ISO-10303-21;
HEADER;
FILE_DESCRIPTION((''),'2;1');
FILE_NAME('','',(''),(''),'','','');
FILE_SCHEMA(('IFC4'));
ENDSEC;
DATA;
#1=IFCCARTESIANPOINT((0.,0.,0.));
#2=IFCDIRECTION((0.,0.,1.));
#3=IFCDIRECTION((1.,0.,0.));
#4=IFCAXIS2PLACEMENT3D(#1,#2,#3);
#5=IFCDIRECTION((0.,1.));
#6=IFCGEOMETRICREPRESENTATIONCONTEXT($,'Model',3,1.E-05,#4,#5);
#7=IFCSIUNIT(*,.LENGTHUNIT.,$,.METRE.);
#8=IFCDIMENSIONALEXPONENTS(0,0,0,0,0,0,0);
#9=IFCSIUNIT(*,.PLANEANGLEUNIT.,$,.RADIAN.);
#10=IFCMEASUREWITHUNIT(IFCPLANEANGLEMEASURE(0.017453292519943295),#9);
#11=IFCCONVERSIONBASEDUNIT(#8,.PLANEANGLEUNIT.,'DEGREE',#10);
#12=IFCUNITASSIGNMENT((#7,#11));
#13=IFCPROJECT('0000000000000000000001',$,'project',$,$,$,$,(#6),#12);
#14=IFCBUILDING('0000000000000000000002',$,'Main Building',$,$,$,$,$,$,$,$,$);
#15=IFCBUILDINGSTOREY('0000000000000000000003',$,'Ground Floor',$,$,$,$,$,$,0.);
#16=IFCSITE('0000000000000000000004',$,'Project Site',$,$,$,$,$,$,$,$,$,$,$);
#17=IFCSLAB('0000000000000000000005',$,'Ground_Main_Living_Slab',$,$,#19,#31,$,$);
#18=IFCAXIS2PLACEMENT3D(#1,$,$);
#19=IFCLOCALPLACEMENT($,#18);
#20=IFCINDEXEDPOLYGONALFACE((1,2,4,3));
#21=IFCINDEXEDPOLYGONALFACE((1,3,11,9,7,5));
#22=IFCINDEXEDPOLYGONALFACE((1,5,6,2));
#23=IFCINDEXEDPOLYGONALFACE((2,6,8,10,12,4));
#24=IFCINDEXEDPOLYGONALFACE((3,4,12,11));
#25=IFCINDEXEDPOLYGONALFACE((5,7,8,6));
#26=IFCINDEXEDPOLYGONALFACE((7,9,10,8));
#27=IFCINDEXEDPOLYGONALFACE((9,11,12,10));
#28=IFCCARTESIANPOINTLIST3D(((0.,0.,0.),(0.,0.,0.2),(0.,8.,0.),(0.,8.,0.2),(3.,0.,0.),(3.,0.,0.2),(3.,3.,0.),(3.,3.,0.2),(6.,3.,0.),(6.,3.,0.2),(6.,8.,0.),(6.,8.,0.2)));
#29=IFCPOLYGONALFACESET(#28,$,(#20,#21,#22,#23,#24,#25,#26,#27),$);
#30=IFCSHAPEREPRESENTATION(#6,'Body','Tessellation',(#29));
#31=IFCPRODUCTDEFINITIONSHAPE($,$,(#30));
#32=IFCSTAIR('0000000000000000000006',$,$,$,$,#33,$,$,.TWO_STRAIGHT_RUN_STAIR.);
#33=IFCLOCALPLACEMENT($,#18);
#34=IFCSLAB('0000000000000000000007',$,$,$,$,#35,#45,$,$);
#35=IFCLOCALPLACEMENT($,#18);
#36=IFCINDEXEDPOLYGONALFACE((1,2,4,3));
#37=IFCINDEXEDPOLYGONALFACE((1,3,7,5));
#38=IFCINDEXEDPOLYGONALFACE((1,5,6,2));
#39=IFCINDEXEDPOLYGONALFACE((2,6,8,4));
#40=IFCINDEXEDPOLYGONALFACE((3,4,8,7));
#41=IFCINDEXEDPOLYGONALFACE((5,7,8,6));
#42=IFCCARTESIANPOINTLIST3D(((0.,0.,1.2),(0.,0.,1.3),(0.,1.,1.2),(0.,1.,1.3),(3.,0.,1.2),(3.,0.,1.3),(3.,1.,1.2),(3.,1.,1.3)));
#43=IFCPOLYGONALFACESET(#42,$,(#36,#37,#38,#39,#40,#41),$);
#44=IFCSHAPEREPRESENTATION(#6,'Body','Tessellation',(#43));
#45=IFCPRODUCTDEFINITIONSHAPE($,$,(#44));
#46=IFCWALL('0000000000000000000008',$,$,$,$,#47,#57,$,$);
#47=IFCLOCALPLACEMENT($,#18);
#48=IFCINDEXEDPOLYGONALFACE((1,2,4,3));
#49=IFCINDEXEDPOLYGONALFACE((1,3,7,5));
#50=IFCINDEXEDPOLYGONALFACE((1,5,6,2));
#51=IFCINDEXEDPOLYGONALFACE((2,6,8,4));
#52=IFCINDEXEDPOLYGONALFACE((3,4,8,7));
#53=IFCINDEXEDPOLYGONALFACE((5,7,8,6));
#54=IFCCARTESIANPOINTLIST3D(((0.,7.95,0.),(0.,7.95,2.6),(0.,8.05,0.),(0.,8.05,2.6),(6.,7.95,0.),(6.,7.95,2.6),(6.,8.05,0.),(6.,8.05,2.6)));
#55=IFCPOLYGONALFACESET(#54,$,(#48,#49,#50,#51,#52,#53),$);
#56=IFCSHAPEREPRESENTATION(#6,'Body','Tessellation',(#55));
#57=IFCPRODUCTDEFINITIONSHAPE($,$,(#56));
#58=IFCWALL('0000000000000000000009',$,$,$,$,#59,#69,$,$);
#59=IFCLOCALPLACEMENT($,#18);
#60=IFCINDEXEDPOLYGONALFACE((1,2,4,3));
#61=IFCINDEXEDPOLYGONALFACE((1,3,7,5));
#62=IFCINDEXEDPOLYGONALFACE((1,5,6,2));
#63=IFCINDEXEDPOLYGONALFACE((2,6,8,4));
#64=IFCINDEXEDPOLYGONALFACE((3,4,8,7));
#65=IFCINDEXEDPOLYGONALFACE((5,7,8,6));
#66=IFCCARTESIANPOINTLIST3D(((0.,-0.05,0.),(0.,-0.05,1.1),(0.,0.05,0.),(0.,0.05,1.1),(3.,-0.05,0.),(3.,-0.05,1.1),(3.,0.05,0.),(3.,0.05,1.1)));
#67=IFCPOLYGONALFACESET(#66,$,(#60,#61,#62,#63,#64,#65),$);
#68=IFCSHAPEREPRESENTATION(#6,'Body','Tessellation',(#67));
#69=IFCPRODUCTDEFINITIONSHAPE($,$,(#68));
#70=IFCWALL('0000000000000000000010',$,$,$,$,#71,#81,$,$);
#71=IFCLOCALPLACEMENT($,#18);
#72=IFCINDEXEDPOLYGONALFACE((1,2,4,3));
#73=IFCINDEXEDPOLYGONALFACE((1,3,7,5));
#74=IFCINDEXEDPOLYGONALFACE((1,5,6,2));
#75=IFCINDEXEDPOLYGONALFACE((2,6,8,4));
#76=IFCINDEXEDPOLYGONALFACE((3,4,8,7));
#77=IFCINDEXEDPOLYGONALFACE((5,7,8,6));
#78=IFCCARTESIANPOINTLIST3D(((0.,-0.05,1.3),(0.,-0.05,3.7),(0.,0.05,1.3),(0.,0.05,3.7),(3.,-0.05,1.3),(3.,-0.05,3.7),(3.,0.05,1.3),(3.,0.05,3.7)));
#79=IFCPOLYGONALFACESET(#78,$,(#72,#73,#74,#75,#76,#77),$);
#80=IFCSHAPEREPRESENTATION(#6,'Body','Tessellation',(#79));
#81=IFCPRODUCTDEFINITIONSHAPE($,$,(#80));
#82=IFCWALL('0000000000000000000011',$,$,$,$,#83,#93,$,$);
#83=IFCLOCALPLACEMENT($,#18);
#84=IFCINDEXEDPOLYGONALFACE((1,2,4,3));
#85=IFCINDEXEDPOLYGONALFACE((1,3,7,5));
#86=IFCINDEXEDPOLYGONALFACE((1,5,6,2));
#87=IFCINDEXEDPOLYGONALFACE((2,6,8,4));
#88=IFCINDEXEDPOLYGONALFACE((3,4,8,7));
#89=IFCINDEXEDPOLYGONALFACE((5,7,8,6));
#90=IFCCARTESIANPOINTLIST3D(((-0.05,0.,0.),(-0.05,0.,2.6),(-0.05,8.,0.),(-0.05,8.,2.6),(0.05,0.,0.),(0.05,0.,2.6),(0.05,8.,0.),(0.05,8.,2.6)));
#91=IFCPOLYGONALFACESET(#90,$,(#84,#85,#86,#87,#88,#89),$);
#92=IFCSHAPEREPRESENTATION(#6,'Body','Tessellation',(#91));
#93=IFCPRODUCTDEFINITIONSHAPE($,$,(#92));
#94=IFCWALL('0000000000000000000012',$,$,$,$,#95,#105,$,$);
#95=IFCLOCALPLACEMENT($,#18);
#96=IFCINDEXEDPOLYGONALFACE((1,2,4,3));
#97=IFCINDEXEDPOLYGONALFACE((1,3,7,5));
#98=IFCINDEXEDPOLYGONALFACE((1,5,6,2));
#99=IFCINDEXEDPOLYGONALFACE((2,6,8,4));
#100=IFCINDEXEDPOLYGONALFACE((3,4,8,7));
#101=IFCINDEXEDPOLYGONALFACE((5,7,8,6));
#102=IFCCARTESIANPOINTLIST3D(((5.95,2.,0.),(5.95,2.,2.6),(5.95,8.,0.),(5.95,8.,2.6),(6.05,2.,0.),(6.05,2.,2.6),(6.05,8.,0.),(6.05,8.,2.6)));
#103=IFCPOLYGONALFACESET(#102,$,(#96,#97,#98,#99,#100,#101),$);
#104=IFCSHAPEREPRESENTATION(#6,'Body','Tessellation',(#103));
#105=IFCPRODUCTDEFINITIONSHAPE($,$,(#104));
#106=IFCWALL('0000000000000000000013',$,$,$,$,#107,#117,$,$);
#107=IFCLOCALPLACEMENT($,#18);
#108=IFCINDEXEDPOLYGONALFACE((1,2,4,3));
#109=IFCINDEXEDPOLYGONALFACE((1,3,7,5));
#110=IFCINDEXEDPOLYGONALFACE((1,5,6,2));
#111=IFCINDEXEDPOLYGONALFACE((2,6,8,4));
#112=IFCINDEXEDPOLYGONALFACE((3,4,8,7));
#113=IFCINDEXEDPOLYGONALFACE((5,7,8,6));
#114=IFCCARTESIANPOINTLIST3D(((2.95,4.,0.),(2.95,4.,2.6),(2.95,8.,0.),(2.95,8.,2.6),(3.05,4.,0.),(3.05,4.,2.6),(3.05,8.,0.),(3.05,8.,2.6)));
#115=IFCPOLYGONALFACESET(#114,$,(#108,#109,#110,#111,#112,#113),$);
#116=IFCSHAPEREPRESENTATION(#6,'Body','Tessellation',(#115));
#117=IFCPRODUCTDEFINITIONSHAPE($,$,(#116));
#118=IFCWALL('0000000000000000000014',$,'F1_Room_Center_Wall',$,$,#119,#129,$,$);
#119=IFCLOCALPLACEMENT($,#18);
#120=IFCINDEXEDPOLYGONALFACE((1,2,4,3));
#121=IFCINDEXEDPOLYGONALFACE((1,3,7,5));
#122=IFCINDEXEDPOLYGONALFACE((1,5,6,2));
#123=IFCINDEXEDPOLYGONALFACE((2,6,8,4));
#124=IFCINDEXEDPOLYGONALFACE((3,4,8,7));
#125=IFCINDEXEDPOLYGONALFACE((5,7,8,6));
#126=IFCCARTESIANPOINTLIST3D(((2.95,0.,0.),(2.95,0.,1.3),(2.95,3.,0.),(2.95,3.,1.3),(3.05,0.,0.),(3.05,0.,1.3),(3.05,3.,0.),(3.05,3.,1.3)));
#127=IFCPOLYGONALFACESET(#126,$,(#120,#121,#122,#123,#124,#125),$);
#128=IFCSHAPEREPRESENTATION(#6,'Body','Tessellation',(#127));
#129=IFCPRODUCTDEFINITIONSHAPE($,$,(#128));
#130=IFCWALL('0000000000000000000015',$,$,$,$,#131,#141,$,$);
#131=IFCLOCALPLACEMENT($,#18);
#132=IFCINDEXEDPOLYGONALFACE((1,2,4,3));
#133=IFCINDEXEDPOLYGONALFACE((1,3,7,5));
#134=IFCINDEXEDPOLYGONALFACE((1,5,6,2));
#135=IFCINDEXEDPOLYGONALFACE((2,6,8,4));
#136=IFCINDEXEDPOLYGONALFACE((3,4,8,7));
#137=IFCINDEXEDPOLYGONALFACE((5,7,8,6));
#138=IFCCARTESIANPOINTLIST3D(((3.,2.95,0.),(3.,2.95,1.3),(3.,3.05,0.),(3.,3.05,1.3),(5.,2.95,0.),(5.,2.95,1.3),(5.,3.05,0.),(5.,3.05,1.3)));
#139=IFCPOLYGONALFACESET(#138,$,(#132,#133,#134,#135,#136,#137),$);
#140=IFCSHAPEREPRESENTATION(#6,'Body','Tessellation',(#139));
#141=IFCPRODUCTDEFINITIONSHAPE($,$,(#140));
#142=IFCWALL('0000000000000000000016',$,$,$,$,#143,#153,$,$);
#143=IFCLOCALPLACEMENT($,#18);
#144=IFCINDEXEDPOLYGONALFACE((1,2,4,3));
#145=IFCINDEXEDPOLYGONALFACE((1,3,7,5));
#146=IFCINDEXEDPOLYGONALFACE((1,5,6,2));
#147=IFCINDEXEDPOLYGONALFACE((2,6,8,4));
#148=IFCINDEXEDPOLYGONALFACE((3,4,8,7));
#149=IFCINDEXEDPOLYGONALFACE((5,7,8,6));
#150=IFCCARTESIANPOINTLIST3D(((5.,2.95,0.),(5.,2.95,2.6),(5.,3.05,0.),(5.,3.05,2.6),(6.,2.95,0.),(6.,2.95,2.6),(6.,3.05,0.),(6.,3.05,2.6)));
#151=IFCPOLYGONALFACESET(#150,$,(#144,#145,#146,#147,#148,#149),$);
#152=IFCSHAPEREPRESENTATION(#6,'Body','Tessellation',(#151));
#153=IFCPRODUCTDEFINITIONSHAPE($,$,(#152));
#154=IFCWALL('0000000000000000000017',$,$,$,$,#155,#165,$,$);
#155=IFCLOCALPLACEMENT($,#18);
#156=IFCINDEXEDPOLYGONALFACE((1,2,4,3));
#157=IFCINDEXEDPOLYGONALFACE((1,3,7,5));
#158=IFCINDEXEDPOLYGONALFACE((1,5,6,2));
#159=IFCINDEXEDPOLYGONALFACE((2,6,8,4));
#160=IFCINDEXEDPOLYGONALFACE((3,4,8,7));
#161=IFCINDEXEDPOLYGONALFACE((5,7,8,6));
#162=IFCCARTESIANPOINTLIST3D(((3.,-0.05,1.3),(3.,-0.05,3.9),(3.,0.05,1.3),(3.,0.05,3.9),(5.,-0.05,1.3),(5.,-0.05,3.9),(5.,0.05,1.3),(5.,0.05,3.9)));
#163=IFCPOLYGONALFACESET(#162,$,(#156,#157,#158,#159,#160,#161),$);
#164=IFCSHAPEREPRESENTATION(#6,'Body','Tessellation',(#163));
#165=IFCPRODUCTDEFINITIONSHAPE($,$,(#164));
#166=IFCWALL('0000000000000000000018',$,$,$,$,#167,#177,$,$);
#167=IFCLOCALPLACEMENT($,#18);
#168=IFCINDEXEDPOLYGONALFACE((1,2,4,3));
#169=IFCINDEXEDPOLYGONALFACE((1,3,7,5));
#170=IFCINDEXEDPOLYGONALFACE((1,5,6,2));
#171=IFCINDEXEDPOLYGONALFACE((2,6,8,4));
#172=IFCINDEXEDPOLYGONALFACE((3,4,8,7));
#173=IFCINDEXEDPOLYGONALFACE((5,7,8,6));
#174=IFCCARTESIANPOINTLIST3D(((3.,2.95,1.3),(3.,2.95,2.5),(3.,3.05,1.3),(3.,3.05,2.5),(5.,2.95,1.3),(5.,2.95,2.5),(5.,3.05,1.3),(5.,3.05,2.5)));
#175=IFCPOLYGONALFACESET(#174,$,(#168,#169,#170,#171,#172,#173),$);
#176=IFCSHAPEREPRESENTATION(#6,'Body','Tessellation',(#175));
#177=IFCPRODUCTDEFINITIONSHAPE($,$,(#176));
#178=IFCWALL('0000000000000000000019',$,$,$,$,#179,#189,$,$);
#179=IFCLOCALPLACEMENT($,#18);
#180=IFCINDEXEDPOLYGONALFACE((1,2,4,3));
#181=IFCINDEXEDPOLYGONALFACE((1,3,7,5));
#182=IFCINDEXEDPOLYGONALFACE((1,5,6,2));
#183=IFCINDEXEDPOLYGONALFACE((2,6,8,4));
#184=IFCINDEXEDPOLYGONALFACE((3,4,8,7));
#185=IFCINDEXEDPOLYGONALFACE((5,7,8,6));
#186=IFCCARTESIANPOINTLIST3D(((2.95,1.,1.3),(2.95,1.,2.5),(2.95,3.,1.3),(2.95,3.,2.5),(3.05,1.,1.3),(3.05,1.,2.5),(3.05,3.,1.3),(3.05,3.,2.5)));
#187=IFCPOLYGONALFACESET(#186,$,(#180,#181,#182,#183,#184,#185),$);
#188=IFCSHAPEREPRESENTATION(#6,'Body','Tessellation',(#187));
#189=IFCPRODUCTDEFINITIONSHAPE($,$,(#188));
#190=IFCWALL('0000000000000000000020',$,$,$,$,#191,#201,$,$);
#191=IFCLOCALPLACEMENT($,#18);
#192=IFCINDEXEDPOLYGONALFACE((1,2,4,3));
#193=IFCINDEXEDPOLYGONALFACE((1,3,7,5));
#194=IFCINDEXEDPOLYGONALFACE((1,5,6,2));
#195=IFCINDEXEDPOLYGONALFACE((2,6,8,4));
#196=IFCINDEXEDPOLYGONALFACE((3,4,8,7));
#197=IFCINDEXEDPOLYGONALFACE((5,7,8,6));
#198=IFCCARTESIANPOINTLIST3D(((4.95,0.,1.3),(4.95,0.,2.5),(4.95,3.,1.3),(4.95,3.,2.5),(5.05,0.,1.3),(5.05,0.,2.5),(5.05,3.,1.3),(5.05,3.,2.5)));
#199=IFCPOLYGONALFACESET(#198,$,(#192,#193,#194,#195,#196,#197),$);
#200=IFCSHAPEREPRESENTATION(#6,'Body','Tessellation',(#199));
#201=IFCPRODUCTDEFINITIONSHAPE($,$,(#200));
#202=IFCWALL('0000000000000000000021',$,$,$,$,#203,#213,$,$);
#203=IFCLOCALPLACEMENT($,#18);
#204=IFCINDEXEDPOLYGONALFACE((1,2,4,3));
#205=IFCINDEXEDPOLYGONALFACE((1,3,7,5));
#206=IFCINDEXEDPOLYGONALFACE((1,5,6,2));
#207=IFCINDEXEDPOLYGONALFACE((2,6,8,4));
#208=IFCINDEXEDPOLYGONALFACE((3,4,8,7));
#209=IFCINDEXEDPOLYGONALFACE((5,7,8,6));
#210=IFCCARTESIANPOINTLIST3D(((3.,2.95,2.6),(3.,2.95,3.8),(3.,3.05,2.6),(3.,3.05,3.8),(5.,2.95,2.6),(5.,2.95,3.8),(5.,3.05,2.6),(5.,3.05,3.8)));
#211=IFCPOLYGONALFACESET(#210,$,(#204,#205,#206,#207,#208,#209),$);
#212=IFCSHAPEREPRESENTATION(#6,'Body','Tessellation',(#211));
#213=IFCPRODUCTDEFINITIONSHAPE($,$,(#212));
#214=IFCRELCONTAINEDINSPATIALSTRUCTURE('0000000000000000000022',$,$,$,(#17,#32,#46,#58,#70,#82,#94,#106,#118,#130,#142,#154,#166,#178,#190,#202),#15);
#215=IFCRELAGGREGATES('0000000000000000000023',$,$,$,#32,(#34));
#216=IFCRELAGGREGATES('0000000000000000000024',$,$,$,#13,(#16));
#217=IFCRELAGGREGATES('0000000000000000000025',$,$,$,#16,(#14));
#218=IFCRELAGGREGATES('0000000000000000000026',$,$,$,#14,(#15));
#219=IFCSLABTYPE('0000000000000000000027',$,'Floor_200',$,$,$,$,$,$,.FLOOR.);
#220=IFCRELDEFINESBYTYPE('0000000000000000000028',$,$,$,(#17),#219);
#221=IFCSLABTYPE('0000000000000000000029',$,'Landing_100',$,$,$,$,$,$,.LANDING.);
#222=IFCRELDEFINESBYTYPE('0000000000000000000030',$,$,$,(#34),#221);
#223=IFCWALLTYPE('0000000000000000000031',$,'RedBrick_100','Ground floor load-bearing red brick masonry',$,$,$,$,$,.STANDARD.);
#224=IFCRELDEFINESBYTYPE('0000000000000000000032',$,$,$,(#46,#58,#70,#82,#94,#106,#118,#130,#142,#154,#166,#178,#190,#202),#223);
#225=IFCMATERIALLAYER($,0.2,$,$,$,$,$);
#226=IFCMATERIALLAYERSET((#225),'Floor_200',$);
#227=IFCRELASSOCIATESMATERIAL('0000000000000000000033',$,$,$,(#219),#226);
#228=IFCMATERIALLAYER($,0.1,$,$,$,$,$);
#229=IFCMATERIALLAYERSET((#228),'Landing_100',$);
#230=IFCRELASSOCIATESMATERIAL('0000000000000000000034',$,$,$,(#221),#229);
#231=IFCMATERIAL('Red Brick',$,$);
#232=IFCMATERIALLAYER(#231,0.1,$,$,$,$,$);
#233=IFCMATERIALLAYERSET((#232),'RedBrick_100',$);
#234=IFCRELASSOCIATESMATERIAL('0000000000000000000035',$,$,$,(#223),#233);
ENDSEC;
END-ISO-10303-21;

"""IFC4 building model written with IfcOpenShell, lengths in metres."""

from ifc_helpers import new_model, entity, si_unit, converted_unit, direction, frame, frame_2d, origin, origin_with_axes, place, context, project, spatial, polyline, rectangle, outline, extrude, material, layer, layer_set, type_object, element, aggregate, save


model = new_model("IFC4")

# Units and contexts
model_context = context("Model", 3, precision=1e-05, world=origin_with_axes(), true_north=direction((0.0, 1.0)))
ifc_project = project(units=[si_unit("LENGTHUNIT", "METRE"), converted_unit("PLANEANGLEUNIT", "DEGREE", entity("IfcPlaneAngleMeasure", 0.017453292519943295), si_unit("PLANEANGLEUNIT", "RADIAN"), dimensions=[0, 0, 0, 0, 0, 0, 0])], contexts=[model_context])

# Site, building, storey
site = spatial("IfcSite", under=ifc_project, Name="Project Site")
building = spatial("IfcBuilding", under=site, Name="Main Building")
storey = spatial("IfcBuildingStorey", under=building, Name="Ground Floor", Elevation=0.0)

# Slab
ifc_layer_1 = layer(None, 0.2)
ifc_layer_set_1 = layer_set([ifc_layer_1], Name="Floor_200")
slab_type_1 = type_object("IfcSlabType", Name="Floor_200", PredefinedType="FLOOR", material=ifc_layer_set_1)
slab_1_placement = place(None, origin_with_axes())
element("IfcSlab", 1, at=slab_1_placement, inside=storey, type_object=slab_type_1, Name="Ground_Main_Living_Slab", context=model_context, shape_type="SweptSolid", body=[
    extrude(outline(polyline([(0.0, 0.0), (3.0, 0.0), (3.0, 3.0), (6.0, 3.0), (6.0, 8.0), (0.0, 8.0), (0.0, 0.0)])), origin(), (0.0, 0.0, 1.0), 0.2),
])

# Stair, slab
stair_placement = place(None, origin_with_axes())
stair = element("IfcStair", 2, at=stair_placement, inside=storey, PredefinedType="TWO_STRAIGHT_RUN_STAIR")
ifc_layer_2 = layer(None, 0.1)
ifc_layer_set_2 = layer_set([ifc_layer_2], Name="Landing_100")
slab_type_2 = type_object("IfcSlabType", Name="Landing_100", PredefinedType="LANDING", material=ifc_layer_set_2)
slab_2_placement = place(stair_placement, frame((0.0, 0.0, 1.2), z_axis=(0.0, 0.0, 1.0), x_axis=(1.0, 0.0, 0.0)))
slab_2 = element("IfcSlab", 3, at=slab_2_placement, type_object=slab_type_2, context=model_context, shape_type="SweptSolid", body=[
    extrude(outline(polyline([(0.0, 0.0), (3.0, 0.0), (3.0, 1.0), (0.0, 1.0), (0.0, 0.0)])), origin(), (0.0, 0.0, 1.0), 0.1),
])

# Walls
ifc_material_1 = material(Name="Red Brick")
ifc_layer_3 = layer(ifc_material_1, 0.1)
ifc_layer_set_3 = layer_set([ifc_layer_3], Name="RedBrick_100")
wall_type = type_object("IfcWallType", Name="RedBrick_100", Description="Ground floor load-bearing red brick masonry", PredefinedType="STANDARD", material=ifc_layer_set_3)
wall_1_placement = place(None, frame((0.0, 8.0, 0.0), z_axis=(0.0, 0.0, 1.0), x_axis=(1.0, 0.0, 0.0)))
element("IfcWall", 4, at=wall_1_placement, inside=storey, type_object=wall_type, context=model_context, shape_type="SweptSolid", body=[
    extrude(rectangle(XDim=6.0, YDim=0.1, at=frame_2d((3.0, 0.0))), origin(), (0.0, 0.0, 1.0), 2.6),
])
wall_2_placement = place(None, origin_with_axes())
element("IfcWall", 5, at=wall_2_placement, inside=storey, type_object=wall_type, context=model_context, shape_type="SweptSolid", body=[
    extrude(rectangle(XDim=3.0, YDim=0.1, at=frame_2d((1.5, 0.0))), origin(), (0.0, 0.0, 1.0), 1.1),
])
wall_3_placement = place(None, frame((0.0, 0.0, 1.3), z_axis=(0.0, 0.0, 1.0), x_axis=(1.0, 0.0, 0.0)))
element("IfcWall", 6, at=wall_3_placement, inside=storey, type_object=wall_type, context=model_context, shape_type="SweptSolid", body=[
    extrude(rectangle(XDim=3.0, YDim=0.1, at=frame_2d((1.5, 0.0))), origin(), (0.0, 0.0, 1.0), 2.4),
])
wall_4_placement = place(None, frame((0.0, 0.0, 0.0), z_axis=(0.0, 0.0, 1.0), x_axis=(0.0, 1.0, 0.0)))
element("IfcWall", 7, at=wall_4_placement, inside=storey, type_object=wall_type, context=model_context, shape_type="SweptSolid", body=[
    extrude(rectangle(XDim=8.0, YDim=0.1, at=frame_2d((4.0, 0.0))), origin(), (0.0, 0.0, 1.0), 2.6),
])
wall_5_placement = place(None, frame((6.0, 2.0, 0.0), z_axis=(0.0, 0.0, 1.0), x_axis=(0.0, 1.0, 0.0)))
element("IfcWall", 8, at=wall_5_placement, inside=storey, type_object=wall_type, context=model_context, shape_type="SweptSolid", body=[
    extrude(rectangle(XDim=6.0, YDim=0.1, at=frame_2d((3.0, 0.0))), origin(), (0.0, 0.0, 1.0), 2.6),
])
wall_6_placement = place(None, frame((3.0, 4.0, 0.0), z_axis=(0.0, 0.0, 1.0), x_axis=(0.0, 1.0, 0.0)))
element("IfcWall", 9, at=wall_6_placement, inside=storey, type_object=wall_type, context=model_context, shape_type="SweptSolid", body=[
    extrude(rectangle(XDim=4.0, YDim=0.1, at=frame_2d((2.0, 0.0))), origin(), (0.0, 0.0, 1.0), 2.6),
])
wall_7_placement = place(None, frame((3.0, 0.0, 0.0), z_axis=(0.0, 0.0, 1.0), x_axis=(0.0, 1.0, 0.0)))
element("IfcWall", 10, at=wall_7_placement, inside=storey, type_object=wall_type, Name="F1_Room_Center_Wall", context=model_context, shape_type="SweptSolid", body=[
    extrude(rectangle(XDim=3.0, YDim=0.1, at=frame_2d((1.5, 0.0))), origin(), (0.0, 0.0, 1.0), 1.3),
])
wall_8_placement = place(None, frame((3.0, 3.0, 0.0), z_axis=(0.0, 0.0, 1.0), x_axis=(1.0, 0.0, 0.0)))
element("IfcWall", 11, at=wall_8_placement, inside=storey, type_object=wall_type, context=model_context, shape_type="SweptSolid", body=[
    extrude(rectangle(XDim=2.0, YDim=0.1, at=frame_2d((1.0, 0.0))), origin(), (0.0, 0.0, 1.0), 1.3),
])
wall_9_placement = place(None, frame((5.0, 3.0, 0.0), z_axis=(0.0, 0.0, 1.0), x_axis=(1.0, 0.0, 0.0)))
element("IfcWall", 12, at=wall_9_placement, inside=storey, type_object=wall_type, context=model_context, shape_type="SweptSolid", body=[
    extrude(rectangle(XDim=1.0, YDim=0.1, at=frame_2d((0.5, 0.0))), origin(), (0.0, 0.0, 1.0), 2.6),
])
wall_10_placement = place(None, frame((3.0, 0.0, 1.3), z_axis=(0.0, 0.0, 1.0), x_axis=(1.0, 0.0, 0.0)))
element("IfcWall", 13, at=wall_10_placement, inside=storey, type_object=wall_type, context=model_context, shape_type="SweptSolid", body=[
    extrude(rectangle(XDim=2.0, YDim=0.1, at=frame_2d((1.0, 0.0))), origin(), (0.0, 0.0, 1.0), 2.6),
])
for number, where, z_axis, x_axis in (
    (14, (3.0, 3.0, 1.3), (0.0, 0.0, 1.0), (1.0, 0.0, 0.0)),
    (15, (3.0, 1.0, 1.3), (0.0, 0.0, 1.0), (0.0, 1.0, 0.0)),
):
    element("IfcWall", number, at=place(None, frame(where, z_axis=z_axis, x_axis=x_axis)), inside=storey, type_object=wall_type, context=model_context, shape_type="SweptSolid", body=[
        extrude(rectangle(XDim=2.0, YDim=0.1, at=frame_2d((1.0, 0.0))), origin(), (0.0, 0.0, 1.0), 1.2),
    ])
wall_11_placement = place(None, frame((5.0, 0.0, 1.3), z_axis=(0.0, 0.0, 1.0), x_axis=(0.0, 1.0, 0.0)))
element("IfcWall", 16, at=wall_11_placement, inside=storey, type_object=wall_type, context=model_context, shape_type="SweptSolid", body=[
    extrude(rectangle(XDim=3.0, YDim=0.1, at=frame_2d((1.5, 0.0))), origin(), (0.0, 0.0, 1.0), 1.2),
])
for number, where, z_axis, x_axis in (
    (17, (3.0, 3.0, 2.6), (0.0, 0.0, 1.0), (1.0, 0.0, 0.0)),
):
    element("IfcWall", number, at=place(None, frame(where, z_axis=z_axis, x_axis=x_axis)), inside=storey, type_object=wall_type, context=model_context, shape_type="SweptSolid", body=[
        extrude(rectangle(XDim=2.0, YDim=0.1, at=frame_2d((1.0, 0.0))), origin(), (0.0, 0.0, 1.0), 1.2),
    ])

aggregate(stair, [slab_2])

save(model, "model.ifc")
